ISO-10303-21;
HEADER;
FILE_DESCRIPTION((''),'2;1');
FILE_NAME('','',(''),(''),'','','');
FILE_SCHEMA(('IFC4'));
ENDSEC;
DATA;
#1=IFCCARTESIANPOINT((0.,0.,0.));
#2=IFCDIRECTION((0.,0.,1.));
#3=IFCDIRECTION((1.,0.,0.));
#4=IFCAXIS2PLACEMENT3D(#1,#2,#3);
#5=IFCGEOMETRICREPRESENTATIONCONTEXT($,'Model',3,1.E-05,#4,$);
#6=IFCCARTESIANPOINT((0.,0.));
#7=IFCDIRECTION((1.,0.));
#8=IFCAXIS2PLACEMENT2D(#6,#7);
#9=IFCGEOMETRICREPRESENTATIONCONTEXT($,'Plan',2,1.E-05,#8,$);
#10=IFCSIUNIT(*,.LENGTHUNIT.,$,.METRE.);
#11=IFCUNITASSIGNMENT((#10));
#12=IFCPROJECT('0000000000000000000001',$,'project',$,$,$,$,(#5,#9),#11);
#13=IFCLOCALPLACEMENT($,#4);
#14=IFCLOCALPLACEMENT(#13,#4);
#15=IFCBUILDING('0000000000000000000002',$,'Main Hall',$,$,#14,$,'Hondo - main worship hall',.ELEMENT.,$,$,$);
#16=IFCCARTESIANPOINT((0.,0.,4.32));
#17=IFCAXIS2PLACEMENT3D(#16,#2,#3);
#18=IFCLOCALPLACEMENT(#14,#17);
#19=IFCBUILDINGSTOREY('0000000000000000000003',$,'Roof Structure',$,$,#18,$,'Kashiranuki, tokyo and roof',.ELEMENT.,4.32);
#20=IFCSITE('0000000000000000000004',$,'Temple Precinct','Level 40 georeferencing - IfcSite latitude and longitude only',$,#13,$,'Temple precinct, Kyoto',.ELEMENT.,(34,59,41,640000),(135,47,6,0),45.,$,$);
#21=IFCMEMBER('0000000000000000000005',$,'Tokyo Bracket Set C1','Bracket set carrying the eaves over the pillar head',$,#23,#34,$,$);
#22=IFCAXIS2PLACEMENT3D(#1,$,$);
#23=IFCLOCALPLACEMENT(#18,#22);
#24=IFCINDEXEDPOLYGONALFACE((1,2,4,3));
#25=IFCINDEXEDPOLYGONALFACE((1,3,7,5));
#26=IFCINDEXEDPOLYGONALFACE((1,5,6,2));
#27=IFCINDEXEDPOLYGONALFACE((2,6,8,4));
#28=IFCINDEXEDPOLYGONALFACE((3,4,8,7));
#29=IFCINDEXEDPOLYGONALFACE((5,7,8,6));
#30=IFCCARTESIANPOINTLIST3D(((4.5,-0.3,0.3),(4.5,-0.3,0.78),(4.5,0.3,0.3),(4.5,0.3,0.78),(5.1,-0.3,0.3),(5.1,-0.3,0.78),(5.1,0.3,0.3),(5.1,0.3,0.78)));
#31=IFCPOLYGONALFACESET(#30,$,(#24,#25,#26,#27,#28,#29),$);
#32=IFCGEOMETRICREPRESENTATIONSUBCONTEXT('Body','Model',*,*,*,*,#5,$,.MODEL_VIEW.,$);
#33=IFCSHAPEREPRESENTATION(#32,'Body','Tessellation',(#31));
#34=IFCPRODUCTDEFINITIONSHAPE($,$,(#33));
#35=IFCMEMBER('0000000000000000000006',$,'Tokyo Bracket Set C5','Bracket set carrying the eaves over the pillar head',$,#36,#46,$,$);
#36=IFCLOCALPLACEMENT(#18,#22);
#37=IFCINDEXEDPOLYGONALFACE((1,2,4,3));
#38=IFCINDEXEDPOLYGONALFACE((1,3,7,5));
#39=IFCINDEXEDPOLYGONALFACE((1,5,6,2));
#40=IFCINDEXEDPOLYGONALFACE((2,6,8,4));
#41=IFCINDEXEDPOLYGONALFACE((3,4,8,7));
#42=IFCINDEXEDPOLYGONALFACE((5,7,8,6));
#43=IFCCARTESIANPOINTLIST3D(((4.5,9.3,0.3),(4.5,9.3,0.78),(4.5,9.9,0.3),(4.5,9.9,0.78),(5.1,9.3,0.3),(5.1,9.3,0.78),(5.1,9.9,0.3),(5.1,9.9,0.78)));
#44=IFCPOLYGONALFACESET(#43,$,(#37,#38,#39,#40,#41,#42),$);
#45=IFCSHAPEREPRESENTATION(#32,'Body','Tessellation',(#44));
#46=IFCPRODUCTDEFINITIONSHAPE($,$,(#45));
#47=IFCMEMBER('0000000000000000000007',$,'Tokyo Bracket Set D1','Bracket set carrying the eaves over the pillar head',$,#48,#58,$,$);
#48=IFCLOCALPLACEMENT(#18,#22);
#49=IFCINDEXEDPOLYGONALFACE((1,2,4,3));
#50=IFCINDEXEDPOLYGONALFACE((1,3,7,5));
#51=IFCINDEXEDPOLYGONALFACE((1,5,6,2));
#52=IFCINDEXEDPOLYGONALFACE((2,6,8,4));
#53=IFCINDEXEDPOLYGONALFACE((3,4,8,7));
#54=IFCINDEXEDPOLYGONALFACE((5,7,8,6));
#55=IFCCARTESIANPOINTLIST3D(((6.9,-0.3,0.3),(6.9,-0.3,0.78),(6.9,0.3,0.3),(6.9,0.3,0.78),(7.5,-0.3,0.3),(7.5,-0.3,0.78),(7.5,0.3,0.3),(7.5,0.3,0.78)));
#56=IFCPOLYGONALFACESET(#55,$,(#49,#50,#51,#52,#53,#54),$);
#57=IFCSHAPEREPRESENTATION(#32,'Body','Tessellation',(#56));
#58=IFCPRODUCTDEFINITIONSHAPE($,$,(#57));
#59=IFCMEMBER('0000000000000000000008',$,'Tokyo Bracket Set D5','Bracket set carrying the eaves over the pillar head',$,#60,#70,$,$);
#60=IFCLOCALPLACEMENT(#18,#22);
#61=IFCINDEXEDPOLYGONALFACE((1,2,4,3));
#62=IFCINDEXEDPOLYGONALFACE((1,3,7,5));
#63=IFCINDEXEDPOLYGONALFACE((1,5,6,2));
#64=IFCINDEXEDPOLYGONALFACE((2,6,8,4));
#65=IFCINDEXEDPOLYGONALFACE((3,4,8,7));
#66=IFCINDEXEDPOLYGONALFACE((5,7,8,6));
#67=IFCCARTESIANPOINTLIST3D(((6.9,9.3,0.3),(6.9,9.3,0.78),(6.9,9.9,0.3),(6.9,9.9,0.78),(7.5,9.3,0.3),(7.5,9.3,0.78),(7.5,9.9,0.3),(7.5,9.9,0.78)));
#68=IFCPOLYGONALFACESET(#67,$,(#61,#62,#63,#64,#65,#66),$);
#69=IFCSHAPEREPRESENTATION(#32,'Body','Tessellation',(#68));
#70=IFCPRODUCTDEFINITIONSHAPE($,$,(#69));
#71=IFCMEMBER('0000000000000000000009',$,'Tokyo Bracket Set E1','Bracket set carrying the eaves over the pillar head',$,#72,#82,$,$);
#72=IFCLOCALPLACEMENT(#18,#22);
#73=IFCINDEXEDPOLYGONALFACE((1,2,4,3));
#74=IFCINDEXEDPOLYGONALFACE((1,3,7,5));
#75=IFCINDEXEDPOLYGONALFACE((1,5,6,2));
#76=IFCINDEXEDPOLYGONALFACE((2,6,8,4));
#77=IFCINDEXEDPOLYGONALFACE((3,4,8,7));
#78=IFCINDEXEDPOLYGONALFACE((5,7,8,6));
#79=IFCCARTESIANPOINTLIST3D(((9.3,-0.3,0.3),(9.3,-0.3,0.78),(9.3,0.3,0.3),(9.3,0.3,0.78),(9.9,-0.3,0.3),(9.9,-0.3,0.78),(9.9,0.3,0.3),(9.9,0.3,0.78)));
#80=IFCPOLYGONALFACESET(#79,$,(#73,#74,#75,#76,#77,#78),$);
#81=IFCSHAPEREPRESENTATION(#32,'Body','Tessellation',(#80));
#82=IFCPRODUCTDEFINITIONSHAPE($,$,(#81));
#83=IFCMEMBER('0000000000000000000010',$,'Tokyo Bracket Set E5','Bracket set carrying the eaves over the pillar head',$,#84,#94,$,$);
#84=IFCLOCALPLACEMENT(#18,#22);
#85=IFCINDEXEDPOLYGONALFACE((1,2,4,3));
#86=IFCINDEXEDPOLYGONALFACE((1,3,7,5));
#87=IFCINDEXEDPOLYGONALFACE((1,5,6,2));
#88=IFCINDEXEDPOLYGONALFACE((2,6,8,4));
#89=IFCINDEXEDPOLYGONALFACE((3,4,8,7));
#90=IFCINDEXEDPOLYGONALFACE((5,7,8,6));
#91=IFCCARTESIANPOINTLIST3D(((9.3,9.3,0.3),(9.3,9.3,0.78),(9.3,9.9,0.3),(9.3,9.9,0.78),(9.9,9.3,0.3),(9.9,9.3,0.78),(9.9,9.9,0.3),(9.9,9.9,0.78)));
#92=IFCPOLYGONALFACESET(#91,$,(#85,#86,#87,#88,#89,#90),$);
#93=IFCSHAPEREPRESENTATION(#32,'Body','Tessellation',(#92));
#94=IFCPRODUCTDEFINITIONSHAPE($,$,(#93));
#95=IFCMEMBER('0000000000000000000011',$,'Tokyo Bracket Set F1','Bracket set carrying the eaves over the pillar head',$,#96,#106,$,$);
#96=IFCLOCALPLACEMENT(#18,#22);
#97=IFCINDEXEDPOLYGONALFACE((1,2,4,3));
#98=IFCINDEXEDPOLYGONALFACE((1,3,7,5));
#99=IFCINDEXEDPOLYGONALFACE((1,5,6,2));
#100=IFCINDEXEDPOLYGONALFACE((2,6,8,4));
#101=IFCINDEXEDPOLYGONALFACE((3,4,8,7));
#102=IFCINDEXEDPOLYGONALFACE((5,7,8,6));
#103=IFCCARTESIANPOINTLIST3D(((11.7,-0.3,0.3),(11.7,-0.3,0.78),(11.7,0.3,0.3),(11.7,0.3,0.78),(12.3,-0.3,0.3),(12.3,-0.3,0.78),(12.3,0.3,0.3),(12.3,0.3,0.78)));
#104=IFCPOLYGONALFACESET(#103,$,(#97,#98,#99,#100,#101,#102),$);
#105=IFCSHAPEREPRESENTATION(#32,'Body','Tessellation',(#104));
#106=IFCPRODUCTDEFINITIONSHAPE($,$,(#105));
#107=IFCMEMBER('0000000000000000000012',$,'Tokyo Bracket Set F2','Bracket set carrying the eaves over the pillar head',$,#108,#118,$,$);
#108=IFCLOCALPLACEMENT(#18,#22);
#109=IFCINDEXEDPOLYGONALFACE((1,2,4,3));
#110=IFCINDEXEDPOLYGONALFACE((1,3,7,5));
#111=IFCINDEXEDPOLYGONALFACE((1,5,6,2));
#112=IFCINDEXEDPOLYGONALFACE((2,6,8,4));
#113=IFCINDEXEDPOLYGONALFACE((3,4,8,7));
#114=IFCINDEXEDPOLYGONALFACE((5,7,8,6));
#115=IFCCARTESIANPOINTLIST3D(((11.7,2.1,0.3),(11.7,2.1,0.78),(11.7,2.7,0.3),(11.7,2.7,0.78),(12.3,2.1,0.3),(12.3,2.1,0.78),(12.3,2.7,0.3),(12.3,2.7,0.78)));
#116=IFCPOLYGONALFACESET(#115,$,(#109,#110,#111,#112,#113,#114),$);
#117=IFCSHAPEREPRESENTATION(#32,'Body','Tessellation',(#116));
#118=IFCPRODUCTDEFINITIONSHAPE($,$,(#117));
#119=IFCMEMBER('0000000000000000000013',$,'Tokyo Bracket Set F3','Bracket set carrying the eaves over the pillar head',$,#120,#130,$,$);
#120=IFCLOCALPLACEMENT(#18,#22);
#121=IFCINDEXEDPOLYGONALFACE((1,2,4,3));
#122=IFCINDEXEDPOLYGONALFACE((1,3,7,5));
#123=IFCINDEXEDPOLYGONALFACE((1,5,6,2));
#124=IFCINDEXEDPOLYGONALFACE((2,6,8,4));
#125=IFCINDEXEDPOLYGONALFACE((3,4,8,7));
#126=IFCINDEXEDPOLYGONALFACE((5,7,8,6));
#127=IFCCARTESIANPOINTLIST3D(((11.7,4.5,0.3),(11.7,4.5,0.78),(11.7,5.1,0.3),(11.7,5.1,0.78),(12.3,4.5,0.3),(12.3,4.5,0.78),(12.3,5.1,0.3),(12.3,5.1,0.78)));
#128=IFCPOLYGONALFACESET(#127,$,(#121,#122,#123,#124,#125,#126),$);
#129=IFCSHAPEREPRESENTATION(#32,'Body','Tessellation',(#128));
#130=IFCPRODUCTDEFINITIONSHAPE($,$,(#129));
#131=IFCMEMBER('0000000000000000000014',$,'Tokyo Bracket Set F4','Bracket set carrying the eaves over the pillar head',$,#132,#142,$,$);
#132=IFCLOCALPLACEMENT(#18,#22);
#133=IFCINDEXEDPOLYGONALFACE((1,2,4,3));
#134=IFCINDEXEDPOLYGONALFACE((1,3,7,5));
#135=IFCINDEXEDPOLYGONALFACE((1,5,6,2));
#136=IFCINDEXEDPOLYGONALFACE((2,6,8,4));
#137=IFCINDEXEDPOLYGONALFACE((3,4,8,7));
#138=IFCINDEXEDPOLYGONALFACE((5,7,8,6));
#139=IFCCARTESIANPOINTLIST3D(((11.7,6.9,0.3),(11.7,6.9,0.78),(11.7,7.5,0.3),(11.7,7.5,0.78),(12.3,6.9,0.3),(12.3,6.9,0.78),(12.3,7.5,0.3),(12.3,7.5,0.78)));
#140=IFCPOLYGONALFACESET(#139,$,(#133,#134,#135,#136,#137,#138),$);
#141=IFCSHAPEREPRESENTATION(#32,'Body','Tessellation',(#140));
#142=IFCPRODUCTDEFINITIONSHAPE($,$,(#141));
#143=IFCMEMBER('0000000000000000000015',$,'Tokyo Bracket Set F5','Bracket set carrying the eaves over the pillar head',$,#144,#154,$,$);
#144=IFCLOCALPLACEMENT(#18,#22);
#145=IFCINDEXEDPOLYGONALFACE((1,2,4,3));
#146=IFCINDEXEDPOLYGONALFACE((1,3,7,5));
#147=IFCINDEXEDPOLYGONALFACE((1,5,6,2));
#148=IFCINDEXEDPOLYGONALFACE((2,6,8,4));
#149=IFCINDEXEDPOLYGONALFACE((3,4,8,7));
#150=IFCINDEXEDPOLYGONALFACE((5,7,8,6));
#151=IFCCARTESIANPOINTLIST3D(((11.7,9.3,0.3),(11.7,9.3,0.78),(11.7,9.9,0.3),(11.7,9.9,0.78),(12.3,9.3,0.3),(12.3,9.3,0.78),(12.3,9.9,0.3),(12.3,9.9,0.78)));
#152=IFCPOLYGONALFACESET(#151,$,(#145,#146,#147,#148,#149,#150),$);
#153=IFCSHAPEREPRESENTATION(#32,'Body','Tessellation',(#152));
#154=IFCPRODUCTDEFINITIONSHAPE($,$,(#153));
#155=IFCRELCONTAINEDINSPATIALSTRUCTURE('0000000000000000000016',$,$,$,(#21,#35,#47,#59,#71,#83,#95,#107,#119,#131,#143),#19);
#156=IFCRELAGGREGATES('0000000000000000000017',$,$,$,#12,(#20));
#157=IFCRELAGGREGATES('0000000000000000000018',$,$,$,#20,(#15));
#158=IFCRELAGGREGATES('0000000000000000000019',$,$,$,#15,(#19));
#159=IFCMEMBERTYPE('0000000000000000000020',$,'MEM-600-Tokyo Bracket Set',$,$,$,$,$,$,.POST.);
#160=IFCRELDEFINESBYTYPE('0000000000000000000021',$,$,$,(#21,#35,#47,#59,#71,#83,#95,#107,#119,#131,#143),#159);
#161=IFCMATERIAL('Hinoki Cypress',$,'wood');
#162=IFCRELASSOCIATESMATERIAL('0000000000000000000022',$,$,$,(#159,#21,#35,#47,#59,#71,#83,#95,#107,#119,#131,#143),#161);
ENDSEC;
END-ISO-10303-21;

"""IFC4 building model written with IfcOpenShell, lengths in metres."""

from ifc_helpers import new_model, si_unit, frame, origin_with_axes, origin_2d_with_axis, place, context, subcontext, project, spatial, line, indexed_curve, rectangle, outline, extrude, material, material_profile, profile_set, profile_usage, type_object, element, save


model = new_model("IFC4")

# Units and contexts
model_context = context("Model", 3, precision=1e-05, world=origin_with_axes())
plan_context = context("Plan", 2, precision=1e-05, world=origin_2d_with_axis())
body_context = subcontext(model_context, "Body", "Model", "MODEL_VIEW")
ifc_project = project(units=[si_unit("LENGTHUNIT", "METRE")], contexts=[model_context, plan_context])

# Site, building, storey
site_placement = place(None, origin_with_axes())
site = spatial("IfcSite", under=ifc_project, at=site_placement, Name="Temple Precinct", Description="Level 40 georeferencing - IfcSite latitude and longitude only", LongName="Temple precinct, Kyoto", CompositionType="ELEMENT", RefLatitude=(34, 59, 41, 640000), RefLongitude=(135, 47, 6, 0), RefElevation=45.0)
building_placement = place(site_placement, origin_with_axes())
building = spatial("IfcBuilding", under=site, at=building_placement, Name="Main Hall", LongName="Hondo - main worship hall", CompositionType="ELEMENT")
storey_placement = place(building_placement, frame((0.0, 0.0, 4.32), z_axis=(0.0, 0.0, 1.0), x_axis=(1.0, 0.0, 0.0)))
storey = spatial("IfcBuildingStorey", under=building, at=storey_placement, Name="Roof Structure", LongName="Kashiranuki, tokyo and roof", CompositionType="ELEMENT", Elevation=4.32)

# Shared definitions
ifc_material_1 = material(Name="Hinoki Cypress", Category="wood")

# Members
ifc_material_profile_1 = material_profile(ifc_material_1, rectangle(XDim=0.6, YDim=0.6))
ifc_profile_set_1 = profile_set([ifc_material_profile_1], Name="MEM-600-Tokyo Bracket Set")
member_type = type_object("IfcMemberType", Name="MEM-600-Tokyo Bracket Set", PredefinedType="POST", material=ifc_profile_set_1)
ifc_profile_usage_1 = profile_usage(ifc_profile_set_1)
member_1_placement = place(storey_placement, frame((4.5, -0.3, 0.3), z_axis=(0.0, 0.0, 1.0), x_axis=(1.0, 0.0, 0.0)))
element("IfcMember", 1, at=member_1_placement, inside=storey, type_object=member_type, material=ifc_profile_usage_1, Name="Tokyo Bracket Set C1", Description="Bracket set carrying the eaves over the pillar head", context=body_context, shape_type="SweptSolid", body=[
    extrude(outline(indexed_curve([(0.0, 0.0), (0.6, 0.0), (0.6, 0.6), (0.0, 0.6)], segments=[line(1, 2, 3, 4, 1)])), origin_with_axes(), (0.0, 0.0, 1.0), 0.48),
])
ifc_profile_usage_2 = profile_usage(ifc_profile_set_1)
member_2_placement = place(storey_placement, frame((4.5, 9.3, 0.3), z_axis=(0.0, 0.0, 1.0), x_axis=(1.0, 0.0, 0.0)))
element("IfcMember", 2, at=member_2_placement, inside=storey, type_object=member_type, material=ifc_profile_usage_2, Name="Tokyo Bracket Set C5", Description="Bracket set carrying the eaves over the pillar head", context=body_context, shape_type="SweptSolid", body=[
    extrude(outline(indexed_curve([(0.0, 0.0), (0.6, 0.0), (0.6, 0.6), (0.0, 0.6)], segments=[line(1, 2, 3, 4, 1)])), origin_with_axes(), (0.0, 0.0, 1.0), 0.48),
])
ifc_profile_usage_3 = profile_usage(ifc_profile_set_1)
member_3_placement = place(storey_placement, frame((6.9, -0.3, 0.3), z_axis=(0.0, 0.0, 1.0), x_axis=(1.0, 0.0, 0.0)))
element("IfcMember", 3, at=member_3_placement, inside=storey, type_object=member_type, material=ifc_profile_usage_3, Name="Tokyo Bracket Set D1", Description="Bracket set carrying the eaves over the pillar head", context=body_context, shape_type="SweptSolid", body=[
    extrude(outline(indexed_curve([(0.0, 0.0), (0.6, 0.0), (0.6, 0.6), (0.0, 0.6)], segments=[line(1, 2, 3, 4, 1)])), origin_with_axes(), (0.0, 0.0, 1.0), 0.48),
])
ifc_profile_usage_4 = profile_usage(ifc_profile_set_1)
member_4_placement = place(storey_placement, frame((6.9, 9.3, 0.3), z_axis=(0.0, 0.0, 1.0), x_axis=(1.0, 0.0, 0.0)))
element("IfcMember", 4, at=member_4_placement, inside=storey, type_object=member_type, material=ifc_profile_usage_4, Name="Tokyo Bracket Set D5", Description="Bracket set carrying the eaves over the pillar head", context=body_context, shape_type="SweptSolid", body=[
    extrude(outline(indexed_curve([(0.0, 0.0), (0.6, 0.0), (0.6, 0.6), (0.0, 0.6)], segments=[line(1, 2, 3, 4, 1)])), origin_with_axes(), (0.0, 0.0, 1.0), 0.48),
])
ifc_profile_usage_5 = profile_usage(ifc_profile_set_1)
member_5_placement = place(storey_placement, frame((9.3, -0.3, 0.3), z_axis=(0.0, 0.0, 1.0), x_axis=(1.0, 0.0, 0.0)))
element("IfcMember", 5, at=member_5_placement, inside=storey, type_object=member_type, material=ifc_profile_usage_5, Name="Tokyo Bracket Set E1", Description="Bracket set carrying the eaves over the pillar head", context=body_context, shape_type="SweptSolid", body=[
    extrude(outline(indexed_curve([(0.0, 0.0), (0.6, 0.0), (0.6, 0.6), (0.0, 0.6)], segments=[line(1, 2, 3, 4, 1)])), origin_with_axes(), (0.0, 0.0, 1.0), 0.48),
])
ifc_profile_usage_6 = profile_usage(ifc_profile_set_1)
member_6_placement = place(storey_placement, frame((9.3, 9.3, 0.3), z_axis=(0.0, 0.0, 1.0), x_axis=(1.0, 0.0, 0.0)))
element("IfcMember", 6, at=member_6_placement, inside=storey, type_object=member_type, material=ifc_profile_usage_6, Name="Tokyo Bracket Set E5", Description="Bracket set carrying the eaves over the pillar head", context=body_context, shape_type="SweptSolid", body=[
    extrude(outline(indexed_curve([(0.0, 0.0), (0.6, 0.0), (0.6, 0.6), (0.0, 0.6)], segments=[line(1, 2, 3, 4, 1)])), origin_with_axes(), (0.0, 0.0, 1.0), 0.48),
])
ifc_profile_usage_7 = profile_usage(ifc_profile_set_1)
member_7_placement = place(storey_placement, frame((11.7, -0.3, 0.3), z_axis=(0.0, 0.0, 1.0), x_axis=(1.0, 0.0, 0.0)))
element("IfcMember", 7, at=member_7_placement, inside=storey, type_object=member_type, material=ifc_profile_usage_7, Name="Tokyo Bracket Set F1", Description="Bracket set carrying the eaves over the pillar head", context=body_context, shape_type="SweptSolid", body=[
    extrude(outline(indexed_curve([(0.0, 0.0), (0.6, 0.0), (0.6, 0.6), (0.0, 0.6)], segments=[line(1, 2, 3, 4, 1)])), origin_with_axes(), (0.0, 0.0, 1.0), 0.48),
])
ifc_profile_usage_8 = profile_usage(ifc_profile_set_1)
member_8_placement = place(storey_placement, frame((11.7, 2.1, 0.3), z_axis=(0.0, 0.0, 1.0), x_axis=(1.0, 0.0, 0.0)))
element("IfcMember", 8, at=member_8_placement, inside=storey, type_object=member_type, material=ifc_profile_usage_8, Name="Tokyo Bracket Set F2", Description="Bracket set carrying the eaves over the pillar head", context=body_context, shape_type="SweptSolid", body=[
    extrude(outline(indexed_curve([(0.0, 0.0), (0.6, 0.0), (0.6, 0.6), (0.0, 0.6)], segments=[line(1, 2, 3, 4, 1)])), origin_with_axes(), (0.0, 0.0, 1.0), 0.48),
])
ifc_profile_usage_9 = profile_usage(ifc_profile_set_1)
member_9_placement = place(storey_placement, frame((11.7, 4.5, 0.3), z_axis=(0.0, 0.0, 1.0), x_axis=(1.0, 0.0, 0.0)))
element("IfcMember", 9, at=member_9_placement, inside=storey, type_object=member_type, material=ifc_profile_usage_9, Name="Tokyo Bracket Set F3", Description="Bracket set carrying the eaves over the pillar head", context=body_context, shape_type="SweptSolid", body=[
    extrude(outline(indexed_curve([(0.0, 0.0), (0.6, 0.0), (0.6, 0.6), (0.0, 0.6)], segments=[line(1, 2, 3, 4, 1)])), origin_with_axes(), (0.0, 0.0, 1.0), 0.48),
])
ifc_profile_usage_10 = profile_usage(ifc_profile_set_1)
member_10_placement = place(storey_placement, frame((11.7, 6.9, 0.3), z_axis=(0.0, 0.0, 1.0), x_axis=(1.0, 0.0, 0.0)))
element("IfcMember", 10, at=member_10_placement, inside=storey, type_object=member_type, material=ifc_profile_usage_10, Name="Tokyo Bracket Set F4", Description="Bracket set carrying the eaves over the pillar head", context=body_context, shape_type="SweptSolid", body=[
    extrude(outline(indexed_curve([(0.0, 0.0), (0.6, 0.0), (0.6, 0.6), (0.0, 0.6)], segments=[line(1, 2, 3, 4, 1)])), origin_with_axes(), (0.0, 0.0, 1.0), 0.48),
])
ifc_profile_usage_11 = profile_usage(ifc_profile_set_1)
member_11_placement = place(storey_placement, frame((11.7, 9.3, 0.3), z_axis=(0.0, 0.0, 1.0), x_axis=(1.0, 0.0, 0.0)))
element("IfcMember", 11, at=member_11_placement, inside=storey, type_object=member_type, material=ifc_profile_usage_11, Name="Tokyo Bracket Set F5", Description="Bracket set carrying the eaves over the pillar head", context=body_context, shape_type="SweptSolid", body=[
    extrude(outline(indexed_curve([(0.0, 0.0), (0.6, 0.0), (0.6, 0.6), (0.0, 0.6)], segments=[line(1, 2, 3, 4, 1)])), origin_with_axes(), (0.0, 0.0, 1.0), 0.48),
])

save(model, "model.ifc")
